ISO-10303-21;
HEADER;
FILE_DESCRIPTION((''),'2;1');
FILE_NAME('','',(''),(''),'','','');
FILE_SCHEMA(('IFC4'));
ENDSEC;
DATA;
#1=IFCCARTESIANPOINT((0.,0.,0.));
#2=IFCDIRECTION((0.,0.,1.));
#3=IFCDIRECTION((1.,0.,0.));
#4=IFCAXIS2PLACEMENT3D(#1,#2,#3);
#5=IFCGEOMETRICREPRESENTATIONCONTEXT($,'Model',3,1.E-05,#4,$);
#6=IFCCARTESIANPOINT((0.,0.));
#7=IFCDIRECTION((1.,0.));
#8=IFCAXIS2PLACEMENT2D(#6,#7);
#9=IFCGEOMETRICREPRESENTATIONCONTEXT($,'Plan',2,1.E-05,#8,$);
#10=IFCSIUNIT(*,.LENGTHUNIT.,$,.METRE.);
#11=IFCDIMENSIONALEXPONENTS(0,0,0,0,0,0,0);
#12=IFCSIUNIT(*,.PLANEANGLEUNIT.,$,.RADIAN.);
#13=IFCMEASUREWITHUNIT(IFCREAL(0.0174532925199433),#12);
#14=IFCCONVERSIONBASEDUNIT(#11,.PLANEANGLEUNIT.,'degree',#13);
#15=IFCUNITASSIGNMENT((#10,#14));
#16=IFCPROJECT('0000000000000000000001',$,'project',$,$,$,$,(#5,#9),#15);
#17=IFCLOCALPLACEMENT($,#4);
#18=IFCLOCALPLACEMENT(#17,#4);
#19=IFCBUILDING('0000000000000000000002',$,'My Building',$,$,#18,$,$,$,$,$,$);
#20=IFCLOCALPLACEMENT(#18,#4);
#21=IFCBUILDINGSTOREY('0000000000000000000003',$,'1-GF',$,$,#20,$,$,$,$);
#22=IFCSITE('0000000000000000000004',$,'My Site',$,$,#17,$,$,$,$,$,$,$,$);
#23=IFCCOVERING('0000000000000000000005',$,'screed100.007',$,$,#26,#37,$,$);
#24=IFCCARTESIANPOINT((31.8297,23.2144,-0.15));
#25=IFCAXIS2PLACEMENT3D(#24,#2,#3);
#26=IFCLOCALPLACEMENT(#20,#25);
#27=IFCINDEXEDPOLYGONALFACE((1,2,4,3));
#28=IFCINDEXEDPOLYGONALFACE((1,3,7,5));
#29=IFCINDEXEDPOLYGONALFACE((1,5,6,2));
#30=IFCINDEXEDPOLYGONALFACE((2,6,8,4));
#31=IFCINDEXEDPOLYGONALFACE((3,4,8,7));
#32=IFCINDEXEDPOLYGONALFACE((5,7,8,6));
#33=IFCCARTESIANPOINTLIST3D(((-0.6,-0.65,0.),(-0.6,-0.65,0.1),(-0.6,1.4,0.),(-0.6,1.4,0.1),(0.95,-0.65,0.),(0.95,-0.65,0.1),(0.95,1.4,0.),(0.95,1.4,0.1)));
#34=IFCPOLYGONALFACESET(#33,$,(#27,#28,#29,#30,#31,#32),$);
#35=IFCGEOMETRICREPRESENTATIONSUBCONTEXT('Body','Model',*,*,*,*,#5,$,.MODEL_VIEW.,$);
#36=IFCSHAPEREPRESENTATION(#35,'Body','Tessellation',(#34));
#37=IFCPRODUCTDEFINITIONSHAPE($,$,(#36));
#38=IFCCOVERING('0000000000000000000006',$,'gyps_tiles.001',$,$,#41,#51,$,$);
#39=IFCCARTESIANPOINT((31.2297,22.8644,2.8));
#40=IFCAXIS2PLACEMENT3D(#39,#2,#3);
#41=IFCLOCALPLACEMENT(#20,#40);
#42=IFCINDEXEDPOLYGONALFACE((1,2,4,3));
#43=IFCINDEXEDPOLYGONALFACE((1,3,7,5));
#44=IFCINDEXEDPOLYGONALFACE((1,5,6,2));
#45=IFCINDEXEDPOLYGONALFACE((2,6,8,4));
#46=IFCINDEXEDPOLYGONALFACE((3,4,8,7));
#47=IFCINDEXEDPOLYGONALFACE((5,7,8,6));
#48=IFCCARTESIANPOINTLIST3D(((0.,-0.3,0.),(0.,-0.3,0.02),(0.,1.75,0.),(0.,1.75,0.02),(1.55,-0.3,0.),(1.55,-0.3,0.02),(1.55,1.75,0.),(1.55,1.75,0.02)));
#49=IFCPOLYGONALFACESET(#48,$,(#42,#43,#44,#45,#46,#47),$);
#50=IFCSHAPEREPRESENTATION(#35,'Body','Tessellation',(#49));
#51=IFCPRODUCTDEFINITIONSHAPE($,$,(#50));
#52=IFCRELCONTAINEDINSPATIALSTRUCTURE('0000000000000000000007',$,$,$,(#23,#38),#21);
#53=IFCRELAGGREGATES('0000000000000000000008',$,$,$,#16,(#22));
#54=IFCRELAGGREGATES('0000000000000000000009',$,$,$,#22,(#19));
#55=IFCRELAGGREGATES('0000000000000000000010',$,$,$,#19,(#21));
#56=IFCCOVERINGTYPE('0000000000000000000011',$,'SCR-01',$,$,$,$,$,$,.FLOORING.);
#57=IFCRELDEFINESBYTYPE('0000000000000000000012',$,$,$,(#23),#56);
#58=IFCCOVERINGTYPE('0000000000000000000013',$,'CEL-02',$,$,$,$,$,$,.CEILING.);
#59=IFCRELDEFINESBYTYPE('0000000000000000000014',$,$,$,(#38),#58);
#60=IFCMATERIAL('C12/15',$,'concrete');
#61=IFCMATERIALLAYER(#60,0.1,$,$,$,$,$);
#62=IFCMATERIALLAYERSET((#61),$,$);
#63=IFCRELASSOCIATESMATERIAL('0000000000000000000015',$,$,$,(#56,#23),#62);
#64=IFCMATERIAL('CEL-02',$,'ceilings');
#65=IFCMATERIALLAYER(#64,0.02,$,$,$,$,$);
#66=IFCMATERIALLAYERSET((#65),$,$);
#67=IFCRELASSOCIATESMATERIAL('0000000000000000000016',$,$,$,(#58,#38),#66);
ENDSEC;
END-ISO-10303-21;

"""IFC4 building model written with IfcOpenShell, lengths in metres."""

from ifc_helpers import new_model, entity, si_unit, converted_unit, frame, origin_with_axes, origin_2d_with_axis, place, context, subcontext, project, spatial, line, indexed_curve, outline, extrude, material, layer, layer_set, layer_usage, type_object, element, save


model = new_model("IFC4")

# Units and contexts
model_context = context("Model", 3, precision=1e-05, world=origin_with_axes())
plan_context = context("Plan", 2, precision=1e-05, world=origin_2d_with_axis())
body_context_1 = subcontext(model_context, "Body", "Model", "MODEL_VIEW")
ifc_project = project(units=[si_unit("LENGTHUNIT", "METRE"), converted_unit("PLANEANGLEUNIT", "degree", entity("IfcReal", 0.0174532925199433), si_unit("PLANEANGLEUNIT", "RADIAN"), dimensions=[0, 0, 0, 0, 0, 0, 0])], contexts=[model_context, plan_context])

# Site, building, storey
site_placement = place(None, origin_with_axes())
site = spatial("IfcSite", under=ifc_project, at=site_placement, Name="My Site")
building_placement = place(site_placement, origin_with_axes())
building = spatial("IfcBuilding", under=site, at=building_placement, Name="My Building")
storey_placement = place(building_placement, origin_with_axes())
storey = spatial("IfcBuildingStorey", under=building, at=storey_placement, Name="1-GF")

# Coverings
ifc_material_1 = material(Name="C12/15", Category="concrete")
ifc_layer_1 = layer(ifc_material_1, 0.1)
ifc_layer_set_1 = layer_set([ifc_layer_1])
ifc_layer_usage_1 = layer_usage(ifc_layer_set_1, "AXIS3", "POSITIVE", 0.0)
covering_type_1 = type_object("IfcCoveringType", Name="SCR-01", PredefinedType="FLOORING", material=ifc_layer_set_1)
covering_1_placement = place(storey_placement, frame((31.8297, 23.2144, -0.15), z_axis=(0.0, 0.0, 1.0), x_axis=(1.0, 0.0, 0.0)))
element("IfcCovering", 1, at=covering_1_placement, inside=storey, type_object=covering_type_1, material=ifc_layer_usage_1, Name="screed100.007", context=body_context_1, shape_type="SweptSolid", body=[
    extrude(outline(indexed_curve([(-0.6, 1.4), (-0.6, -0.65), (0.95, -0.65), (0.95, 1.4)], segments=[line(3, 2), line(2, 1), line(1, 4), line(4, 3)], self_intersect=False)), None, (0.0, 0.0, 1.0), 0.1),
])
ifc_material_2 = material(Name="CEL-02", Category="ceilings")
ifc_layer_2 = layer(ifc_material_2, 0.02)
ifc_layer_set_2 = layer_set([ifc_layer_2])
covering_type_2 = type_object("IfcCoveringType", Name="CEL-02", PredefinedType="CEILING", material=ifc_layer_set_2)
ifc_layer_usage_2 = layer_usage(ifc_layer_set_2, "AXIS3", "POSITIVE", 0.0)
covering_2_placement = place(storey_placement, frame((31.2297, 22.8644, 2.8), z_axis=(0.0, 0.0, 1.0), x_axis=(1.0, 0.0, 0.0)))
element("IfcCovering", 2, at=covering_2_placement, inside=storey, type_object=covering_type_2, material=ifc_layer_usage_2, Name="gyps_tiles.001", context=body_context_1, shape_type="SweptSolid", body=[
    extrude(outline(indexed_curve([(1.55, 1.75), (1.55, -0.3), (0.0, -0.3), (0.0, 1.75)], segments=[line(3, 2), line(2, 1), line(1, 4), line(4, 3)], self_intersect=False)), None, (0.0, 0.0, 1.0), 0.02),
])

save(model, "model.ifc")
